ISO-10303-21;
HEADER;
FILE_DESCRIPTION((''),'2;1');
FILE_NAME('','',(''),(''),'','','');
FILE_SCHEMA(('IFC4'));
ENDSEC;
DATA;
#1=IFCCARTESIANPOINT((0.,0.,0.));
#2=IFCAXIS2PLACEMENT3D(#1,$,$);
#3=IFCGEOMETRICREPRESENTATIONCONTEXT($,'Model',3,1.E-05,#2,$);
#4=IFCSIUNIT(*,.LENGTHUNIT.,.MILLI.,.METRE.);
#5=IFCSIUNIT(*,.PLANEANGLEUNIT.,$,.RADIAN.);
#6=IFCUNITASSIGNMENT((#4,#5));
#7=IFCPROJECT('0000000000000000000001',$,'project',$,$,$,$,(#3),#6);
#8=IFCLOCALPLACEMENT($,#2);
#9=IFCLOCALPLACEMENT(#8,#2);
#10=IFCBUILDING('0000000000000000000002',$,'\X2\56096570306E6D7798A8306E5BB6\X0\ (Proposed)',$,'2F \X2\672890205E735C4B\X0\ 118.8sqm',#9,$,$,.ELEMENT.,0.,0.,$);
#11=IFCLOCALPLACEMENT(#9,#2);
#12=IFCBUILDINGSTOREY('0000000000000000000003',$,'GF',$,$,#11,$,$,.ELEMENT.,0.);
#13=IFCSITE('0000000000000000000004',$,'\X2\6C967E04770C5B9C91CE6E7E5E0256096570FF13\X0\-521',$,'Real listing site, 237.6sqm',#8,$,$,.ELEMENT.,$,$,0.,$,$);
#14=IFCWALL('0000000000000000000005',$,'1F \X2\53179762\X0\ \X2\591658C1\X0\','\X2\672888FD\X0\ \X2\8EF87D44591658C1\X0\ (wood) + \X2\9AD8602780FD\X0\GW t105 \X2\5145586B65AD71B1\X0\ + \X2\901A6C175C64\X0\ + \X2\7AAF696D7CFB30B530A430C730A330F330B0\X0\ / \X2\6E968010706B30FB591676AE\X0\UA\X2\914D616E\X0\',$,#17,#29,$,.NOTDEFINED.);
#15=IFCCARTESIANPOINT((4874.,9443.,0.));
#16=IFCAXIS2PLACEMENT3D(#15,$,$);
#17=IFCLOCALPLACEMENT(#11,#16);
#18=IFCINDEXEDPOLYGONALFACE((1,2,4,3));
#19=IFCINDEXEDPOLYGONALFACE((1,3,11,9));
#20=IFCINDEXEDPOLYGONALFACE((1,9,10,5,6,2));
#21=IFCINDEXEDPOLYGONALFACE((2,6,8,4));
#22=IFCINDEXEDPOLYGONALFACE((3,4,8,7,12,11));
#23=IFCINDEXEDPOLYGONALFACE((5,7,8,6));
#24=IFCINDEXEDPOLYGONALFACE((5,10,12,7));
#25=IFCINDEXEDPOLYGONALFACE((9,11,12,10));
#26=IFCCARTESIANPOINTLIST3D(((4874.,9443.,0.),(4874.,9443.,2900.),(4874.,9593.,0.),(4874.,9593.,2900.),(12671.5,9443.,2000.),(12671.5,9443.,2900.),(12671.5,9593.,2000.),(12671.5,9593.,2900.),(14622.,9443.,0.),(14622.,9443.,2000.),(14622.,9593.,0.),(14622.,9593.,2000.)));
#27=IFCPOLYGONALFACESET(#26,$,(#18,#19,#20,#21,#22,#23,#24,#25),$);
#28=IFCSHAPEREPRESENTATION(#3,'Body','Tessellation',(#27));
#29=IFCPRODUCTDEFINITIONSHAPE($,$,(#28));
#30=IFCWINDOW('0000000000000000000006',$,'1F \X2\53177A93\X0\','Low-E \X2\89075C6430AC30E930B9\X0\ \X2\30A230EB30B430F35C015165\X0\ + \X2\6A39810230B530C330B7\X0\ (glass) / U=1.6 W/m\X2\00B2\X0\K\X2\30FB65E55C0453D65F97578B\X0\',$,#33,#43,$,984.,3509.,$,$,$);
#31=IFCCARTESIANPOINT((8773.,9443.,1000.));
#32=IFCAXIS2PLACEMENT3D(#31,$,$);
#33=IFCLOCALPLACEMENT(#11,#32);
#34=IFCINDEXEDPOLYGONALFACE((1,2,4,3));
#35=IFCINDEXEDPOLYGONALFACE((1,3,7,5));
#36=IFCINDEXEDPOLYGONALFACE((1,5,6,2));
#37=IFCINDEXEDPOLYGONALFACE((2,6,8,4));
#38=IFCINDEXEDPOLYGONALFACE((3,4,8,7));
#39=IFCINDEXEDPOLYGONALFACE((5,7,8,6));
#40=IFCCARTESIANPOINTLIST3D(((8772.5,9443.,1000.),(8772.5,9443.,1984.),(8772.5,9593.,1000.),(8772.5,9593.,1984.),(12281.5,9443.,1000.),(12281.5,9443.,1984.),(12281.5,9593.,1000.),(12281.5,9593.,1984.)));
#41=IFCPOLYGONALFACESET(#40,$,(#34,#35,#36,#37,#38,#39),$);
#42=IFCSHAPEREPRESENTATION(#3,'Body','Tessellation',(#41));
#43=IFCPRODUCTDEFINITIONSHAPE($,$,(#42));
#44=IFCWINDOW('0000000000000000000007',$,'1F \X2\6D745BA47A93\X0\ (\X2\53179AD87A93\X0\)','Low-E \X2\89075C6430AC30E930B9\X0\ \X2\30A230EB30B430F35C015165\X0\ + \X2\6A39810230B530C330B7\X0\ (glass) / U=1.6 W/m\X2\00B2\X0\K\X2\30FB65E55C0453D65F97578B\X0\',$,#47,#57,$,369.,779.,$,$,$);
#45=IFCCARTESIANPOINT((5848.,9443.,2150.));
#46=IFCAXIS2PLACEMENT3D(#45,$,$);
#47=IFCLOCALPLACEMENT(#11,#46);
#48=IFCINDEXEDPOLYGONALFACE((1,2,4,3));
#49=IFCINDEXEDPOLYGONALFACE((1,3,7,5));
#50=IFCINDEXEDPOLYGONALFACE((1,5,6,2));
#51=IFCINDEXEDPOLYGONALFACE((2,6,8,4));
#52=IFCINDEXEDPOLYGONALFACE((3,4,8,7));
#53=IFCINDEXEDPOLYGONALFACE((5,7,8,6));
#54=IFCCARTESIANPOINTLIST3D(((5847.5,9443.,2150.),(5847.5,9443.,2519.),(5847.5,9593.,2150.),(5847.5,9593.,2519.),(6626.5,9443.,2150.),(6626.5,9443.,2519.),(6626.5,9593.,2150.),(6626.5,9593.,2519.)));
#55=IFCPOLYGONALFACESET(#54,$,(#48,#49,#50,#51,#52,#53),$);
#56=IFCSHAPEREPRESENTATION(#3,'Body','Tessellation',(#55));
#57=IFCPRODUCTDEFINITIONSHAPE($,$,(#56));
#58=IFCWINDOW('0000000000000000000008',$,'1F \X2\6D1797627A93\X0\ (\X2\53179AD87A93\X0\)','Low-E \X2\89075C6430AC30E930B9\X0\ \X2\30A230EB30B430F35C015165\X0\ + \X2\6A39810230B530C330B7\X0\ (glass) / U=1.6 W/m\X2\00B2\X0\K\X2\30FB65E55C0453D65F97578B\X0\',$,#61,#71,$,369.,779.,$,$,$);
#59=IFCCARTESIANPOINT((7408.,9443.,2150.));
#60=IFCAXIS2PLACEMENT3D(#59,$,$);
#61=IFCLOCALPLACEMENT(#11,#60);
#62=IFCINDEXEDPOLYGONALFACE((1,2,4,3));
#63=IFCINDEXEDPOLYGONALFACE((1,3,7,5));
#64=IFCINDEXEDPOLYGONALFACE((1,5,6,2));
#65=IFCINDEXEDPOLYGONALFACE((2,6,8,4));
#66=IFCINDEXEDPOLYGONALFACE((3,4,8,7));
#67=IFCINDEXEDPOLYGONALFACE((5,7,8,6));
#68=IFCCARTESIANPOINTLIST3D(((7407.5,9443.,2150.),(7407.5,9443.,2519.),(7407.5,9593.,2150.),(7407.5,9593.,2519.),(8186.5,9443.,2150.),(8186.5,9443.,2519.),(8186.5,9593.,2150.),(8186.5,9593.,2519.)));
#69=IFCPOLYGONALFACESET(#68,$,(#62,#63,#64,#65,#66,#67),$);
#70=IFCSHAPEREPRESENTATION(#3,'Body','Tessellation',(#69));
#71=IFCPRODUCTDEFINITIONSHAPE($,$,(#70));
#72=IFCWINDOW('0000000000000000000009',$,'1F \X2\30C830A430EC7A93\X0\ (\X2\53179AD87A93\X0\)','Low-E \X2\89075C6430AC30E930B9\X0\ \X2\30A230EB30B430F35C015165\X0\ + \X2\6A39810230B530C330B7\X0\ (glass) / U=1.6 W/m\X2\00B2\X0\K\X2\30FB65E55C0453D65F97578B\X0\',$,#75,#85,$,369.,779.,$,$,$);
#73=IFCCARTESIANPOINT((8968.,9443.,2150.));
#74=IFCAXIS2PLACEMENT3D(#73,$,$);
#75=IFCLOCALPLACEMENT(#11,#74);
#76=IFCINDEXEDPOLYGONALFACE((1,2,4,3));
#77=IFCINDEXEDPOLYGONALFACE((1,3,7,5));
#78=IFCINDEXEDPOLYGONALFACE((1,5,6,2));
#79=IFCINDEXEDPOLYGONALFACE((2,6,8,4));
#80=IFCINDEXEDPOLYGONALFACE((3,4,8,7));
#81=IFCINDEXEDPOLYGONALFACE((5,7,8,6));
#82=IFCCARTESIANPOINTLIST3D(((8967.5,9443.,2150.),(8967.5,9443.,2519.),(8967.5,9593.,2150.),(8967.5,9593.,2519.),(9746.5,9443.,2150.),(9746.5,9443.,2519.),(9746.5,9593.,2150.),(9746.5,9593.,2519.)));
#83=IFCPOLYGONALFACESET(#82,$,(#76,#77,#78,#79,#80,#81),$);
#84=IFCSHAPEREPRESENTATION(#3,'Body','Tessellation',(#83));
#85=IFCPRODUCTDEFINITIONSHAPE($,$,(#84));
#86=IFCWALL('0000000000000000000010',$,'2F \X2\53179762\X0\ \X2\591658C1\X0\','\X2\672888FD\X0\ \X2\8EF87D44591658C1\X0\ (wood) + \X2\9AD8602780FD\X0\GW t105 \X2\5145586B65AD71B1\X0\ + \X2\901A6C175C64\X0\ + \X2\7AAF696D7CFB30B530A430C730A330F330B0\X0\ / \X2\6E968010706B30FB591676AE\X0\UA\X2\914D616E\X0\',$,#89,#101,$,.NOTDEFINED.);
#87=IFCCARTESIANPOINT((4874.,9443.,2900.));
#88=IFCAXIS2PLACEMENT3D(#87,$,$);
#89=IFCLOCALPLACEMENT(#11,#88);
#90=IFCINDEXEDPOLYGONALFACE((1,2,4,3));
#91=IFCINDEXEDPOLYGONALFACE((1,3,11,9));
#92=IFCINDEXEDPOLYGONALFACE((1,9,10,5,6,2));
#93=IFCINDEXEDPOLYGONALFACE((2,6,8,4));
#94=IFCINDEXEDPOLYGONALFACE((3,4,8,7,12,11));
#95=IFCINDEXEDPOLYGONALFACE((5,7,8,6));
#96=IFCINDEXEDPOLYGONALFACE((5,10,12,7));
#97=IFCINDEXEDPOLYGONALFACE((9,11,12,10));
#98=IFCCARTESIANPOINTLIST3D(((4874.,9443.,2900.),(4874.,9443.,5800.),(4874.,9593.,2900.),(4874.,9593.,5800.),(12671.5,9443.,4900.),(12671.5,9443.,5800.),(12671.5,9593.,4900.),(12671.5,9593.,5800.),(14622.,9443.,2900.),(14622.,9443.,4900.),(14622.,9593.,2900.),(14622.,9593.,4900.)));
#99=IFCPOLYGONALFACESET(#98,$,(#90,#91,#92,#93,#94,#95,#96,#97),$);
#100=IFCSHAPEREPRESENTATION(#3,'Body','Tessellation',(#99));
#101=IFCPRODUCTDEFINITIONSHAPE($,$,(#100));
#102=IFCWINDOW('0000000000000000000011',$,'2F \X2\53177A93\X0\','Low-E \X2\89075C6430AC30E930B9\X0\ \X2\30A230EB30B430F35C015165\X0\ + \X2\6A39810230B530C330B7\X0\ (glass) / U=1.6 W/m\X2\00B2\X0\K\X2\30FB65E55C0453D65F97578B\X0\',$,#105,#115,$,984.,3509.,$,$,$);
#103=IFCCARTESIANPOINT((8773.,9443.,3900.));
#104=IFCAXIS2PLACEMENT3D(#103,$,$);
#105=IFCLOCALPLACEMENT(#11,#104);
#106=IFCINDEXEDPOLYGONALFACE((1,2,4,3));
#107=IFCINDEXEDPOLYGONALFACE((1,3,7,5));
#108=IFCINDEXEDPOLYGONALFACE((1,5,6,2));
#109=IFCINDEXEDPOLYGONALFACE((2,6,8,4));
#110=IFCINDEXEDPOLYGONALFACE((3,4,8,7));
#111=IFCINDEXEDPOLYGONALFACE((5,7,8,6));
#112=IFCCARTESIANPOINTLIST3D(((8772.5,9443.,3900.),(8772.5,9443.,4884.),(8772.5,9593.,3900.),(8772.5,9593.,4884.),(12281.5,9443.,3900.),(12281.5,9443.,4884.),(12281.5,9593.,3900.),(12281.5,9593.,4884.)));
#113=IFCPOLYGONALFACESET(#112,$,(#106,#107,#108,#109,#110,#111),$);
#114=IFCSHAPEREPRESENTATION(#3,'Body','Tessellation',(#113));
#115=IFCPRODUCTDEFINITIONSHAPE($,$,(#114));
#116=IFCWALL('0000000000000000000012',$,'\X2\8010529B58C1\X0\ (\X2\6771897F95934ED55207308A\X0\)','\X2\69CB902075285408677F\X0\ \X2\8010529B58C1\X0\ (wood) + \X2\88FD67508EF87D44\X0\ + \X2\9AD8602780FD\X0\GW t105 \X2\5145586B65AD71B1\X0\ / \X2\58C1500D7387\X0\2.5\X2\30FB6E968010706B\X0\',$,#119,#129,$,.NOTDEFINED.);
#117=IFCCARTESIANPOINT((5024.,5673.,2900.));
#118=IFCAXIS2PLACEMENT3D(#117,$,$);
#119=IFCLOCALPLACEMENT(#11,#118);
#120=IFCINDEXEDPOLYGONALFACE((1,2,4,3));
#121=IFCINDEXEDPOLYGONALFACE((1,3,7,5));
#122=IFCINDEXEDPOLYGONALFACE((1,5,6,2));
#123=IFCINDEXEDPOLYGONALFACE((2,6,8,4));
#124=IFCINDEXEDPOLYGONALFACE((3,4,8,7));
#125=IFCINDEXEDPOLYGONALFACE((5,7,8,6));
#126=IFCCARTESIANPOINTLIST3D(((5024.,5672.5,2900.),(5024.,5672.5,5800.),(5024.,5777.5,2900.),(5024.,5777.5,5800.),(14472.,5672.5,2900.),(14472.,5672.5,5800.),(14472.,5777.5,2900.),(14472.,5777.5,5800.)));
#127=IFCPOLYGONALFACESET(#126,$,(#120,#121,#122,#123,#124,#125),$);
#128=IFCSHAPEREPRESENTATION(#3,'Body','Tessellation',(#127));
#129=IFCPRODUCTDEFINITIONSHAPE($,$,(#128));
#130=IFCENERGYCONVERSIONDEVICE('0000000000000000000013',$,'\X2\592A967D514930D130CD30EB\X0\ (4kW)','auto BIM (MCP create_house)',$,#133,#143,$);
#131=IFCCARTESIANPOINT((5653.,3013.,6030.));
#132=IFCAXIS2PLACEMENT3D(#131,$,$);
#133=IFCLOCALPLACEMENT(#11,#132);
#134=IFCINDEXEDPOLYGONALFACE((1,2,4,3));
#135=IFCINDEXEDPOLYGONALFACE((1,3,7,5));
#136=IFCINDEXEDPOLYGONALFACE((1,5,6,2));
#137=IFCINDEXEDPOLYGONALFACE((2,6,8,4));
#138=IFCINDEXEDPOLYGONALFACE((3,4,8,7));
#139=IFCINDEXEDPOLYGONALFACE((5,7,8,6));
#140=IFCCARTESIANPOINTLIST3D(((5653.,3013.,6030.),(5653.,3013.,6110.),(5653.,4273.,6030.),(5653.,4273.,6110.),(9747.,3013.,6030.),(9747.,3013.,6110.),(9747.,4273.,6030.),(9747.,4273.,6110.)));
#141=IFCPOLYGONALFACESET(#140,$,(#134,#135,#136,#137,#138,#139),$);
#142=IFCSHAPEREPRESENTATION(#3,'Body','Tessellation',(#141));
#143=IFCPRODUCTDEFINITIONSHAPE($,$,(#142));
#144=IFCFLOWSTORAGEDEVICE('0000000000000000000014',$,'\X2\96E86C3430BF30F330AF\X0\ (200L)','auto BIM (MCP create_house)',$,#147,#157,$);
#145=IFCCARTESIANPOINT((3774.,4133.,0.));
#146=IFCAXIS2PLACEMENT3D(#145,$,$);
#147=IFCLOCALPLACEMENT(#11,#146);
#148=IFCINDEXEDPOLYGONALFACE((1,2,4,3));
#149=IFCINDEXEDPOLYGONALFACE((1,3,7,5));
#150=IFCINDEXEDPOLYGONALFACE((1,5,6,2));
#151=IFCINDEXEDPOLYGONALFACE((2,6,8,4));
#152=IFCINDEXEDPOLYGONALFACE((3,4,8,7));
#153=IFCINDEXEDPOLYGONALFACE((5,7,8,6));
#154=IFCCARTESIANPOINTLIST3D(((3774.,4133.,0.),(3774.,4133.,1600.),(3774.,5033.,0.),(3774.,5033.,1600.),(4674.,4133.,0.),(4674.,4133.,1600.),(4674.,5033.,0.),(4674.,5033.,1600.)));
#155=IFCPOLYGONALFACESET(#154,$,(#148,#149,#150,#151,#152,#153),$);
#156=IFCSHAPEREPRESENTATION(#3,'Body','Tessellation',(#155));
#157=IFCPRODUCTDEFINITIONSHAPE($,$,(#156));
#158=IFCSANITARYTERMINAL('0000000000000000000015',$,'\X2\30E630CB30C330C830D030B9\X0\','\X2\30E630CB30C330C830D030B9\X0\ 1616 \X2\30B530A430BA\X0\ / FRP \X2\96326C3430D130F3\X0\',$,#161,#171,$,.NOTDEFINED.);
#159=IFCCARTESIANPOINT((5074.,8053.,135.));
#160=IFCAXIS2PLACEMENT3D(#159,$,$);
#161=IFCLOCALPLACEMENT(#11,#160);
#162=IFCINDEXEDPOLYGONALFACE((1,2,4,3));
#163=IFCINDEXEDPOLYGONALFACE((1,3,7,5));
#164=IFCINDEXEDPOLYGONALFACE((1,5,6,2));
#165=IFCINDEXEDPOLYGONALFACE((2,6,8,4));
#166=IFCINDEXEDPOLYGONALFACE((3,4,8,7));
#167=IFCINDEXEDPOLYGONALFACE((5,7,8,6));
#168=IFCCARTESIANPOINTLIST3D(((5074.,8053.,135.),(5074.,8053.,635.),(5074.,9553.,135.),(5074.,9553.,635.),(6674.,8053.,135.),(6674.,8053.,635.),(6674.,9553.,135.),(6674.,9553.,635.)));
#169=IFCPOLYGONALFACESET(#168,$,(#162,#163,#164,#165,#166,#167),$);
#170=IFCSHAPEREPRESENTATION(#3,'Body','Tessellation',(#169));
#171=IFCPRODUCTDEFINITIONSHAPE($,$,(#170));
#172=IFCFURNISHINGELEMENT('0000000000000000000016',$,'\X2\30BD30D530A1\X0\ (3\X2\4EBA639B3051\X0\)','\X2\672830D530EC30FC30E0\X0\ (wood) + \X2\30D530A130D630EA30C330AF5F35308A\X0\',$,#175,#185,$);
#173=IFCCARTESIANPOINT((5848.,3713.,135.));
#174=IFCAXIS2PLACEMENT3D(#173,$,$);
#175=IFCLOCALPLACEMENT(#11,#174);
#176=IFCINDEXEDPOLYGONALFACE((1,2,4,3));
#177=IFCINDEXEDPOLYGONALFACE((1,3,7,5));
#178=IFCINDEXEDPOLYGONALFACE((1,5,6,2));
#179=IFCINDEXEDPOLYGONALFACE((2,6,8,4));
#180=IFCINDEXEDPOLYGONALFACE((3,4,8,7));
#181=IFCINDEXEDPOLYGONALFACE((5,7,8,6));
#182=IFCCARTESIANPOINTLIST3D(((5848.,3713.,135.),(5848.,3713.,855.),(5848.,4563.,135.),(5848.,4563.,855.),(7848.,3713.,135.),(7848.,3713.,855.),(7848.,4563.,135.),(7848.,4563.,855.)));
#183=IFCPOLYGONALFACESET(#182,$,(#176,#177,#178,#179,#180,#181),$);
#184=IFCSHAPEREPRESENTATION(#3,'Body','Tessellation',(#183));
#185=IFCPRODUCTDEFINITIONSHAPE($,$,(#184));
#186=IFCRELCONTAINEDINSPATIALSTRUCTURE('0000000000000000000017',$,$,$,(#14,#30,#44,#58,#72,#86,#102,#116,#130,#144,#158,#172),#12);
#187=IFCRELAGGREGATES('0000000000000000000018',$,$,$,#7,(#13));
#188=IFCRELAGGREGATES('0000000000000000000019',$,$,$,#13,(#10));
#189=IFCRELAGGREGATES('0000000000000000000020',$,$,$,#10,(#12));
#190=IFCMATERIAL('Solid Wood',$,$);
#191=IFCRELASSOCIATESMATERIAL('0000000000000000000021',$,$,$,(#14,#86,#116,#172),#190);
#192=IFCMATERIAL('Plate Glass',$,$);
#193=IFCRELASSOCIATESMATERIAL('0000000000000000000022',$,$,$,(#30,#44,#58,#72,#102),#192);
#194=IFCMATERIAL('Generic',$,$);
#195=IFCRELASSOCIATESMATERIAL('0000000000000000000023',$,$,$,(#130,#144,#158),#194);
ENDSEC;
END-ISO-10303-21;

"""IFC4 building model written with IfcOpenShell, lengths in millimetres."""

from ifc_helpers import new_model, si_unit, frame, frame_2d, origin, place, context, project, spatial, rectangle, extrude, material, element, fill, save


model = new_model("IFC4")

# Units and contexts
model_context = context("Model", 3, precision=1e-05, world=origin())
ifc_project = project(units=[si_unit("LENGTHUNIT", "METRE", prefix="MILLI"), si_unit("PLANEANGLEUNIT", "RADIAN")], contexts=[model_context])

# Site, building, storey
site_placement = place(None, origin())
site = spatial("IfcSite", under=ifc_project, at=site_placement, Name="沖縄県宜野湾市嘉数３-521", ObjectType="Real listing site, 237.6sqm", CompositionType="ELEMENT", RefElevation=0.0)
building_placement = place(site_placement, origin())
building = spatial("IfcBuilding", under=site, at=building_placement, Name="嘉数の海風の家 (Proposed)", ObjectType="2F 木造平屋 118.8sqm", CompositionType="ELEMENT", ElevationOfRefHeight=0.0, ElevationOfTerrain=0.0)
storey_placement = place(building_placement, origin())
storey = spatial("IfcBuildingStorey", under=building, at=storey_placement, Name="GF", CompositionType="ELEMENT", Elevation=0.0)

# Wall, openings, windows
ifc_material_1 = material(Name="Solid Wood")
wall_1_placement = place(storey_placement, frame((4874.0, 9443.0, 0.0)))
wall_1 = element("IfcWall", 1, at=wall_1_placement, inside=storey, material=ifc_material_1, Name="1F 北面 外壁", Description="木製 軸組外壁 (wood) + 高性能GW t105 充填断熱 + 通気層 + 窯業系サイディング / 準耐火・外皮UA配慮", PredefinedType="NOTDEFINED", context=model_context, shape_type="SweptSolid", body=[
    extrude(rectangle(XDim=9748.0, YDim=150.0, at=frame_2d((4874.0, 75.0))), frame((4874.0, 9443.0, 0.0)), (0.0, 0.0, 1.0), 2900.0),
])
opening_1_placement = place(storey_placement, frame((8773.0, 9443.0, 1000.0)))
opening_1 = element("IfcOpeningElement", 2, at=opening_1_placement, cuts=wall_1, PredefinedType="NOTDEFINED", context=model_context, shape_type="SweptSolid", body=[
    extrude(rectangle(XDim=3509.0, YDim=150.0, at=frame_2d((1754.0, 75.0))), frame((8773.0, 9443.0, 1000.0)), (0.0, 0.0, 1.0), 984.0),
])
opening_2_placement = place(storey_placement, frame((5848.0, 9443.0, 2150.0)))
opening_2 = element("IfcOpeningElement", 3, at=opening_2_placement, cuts=wall_1, PredefinedType="NOTDEFINED", context=model_context, shape_type="SweptSolid", body=[
    extrude(rectangle(XDim=779.0, YDim=150.0, at=frame_2d((389.0, 75.0))), frame((5848.0, 9443.0, 2150.0)), (0.0, 0.0, 1.0), 369.0),
])
opening_3_placement = place(storey_placement, frame((7408.0, 9443.0, 2150.0)))
opening_3 = element("IfcOpeningElement", 4, at=opening_3_placement, cuts=wall_1, PredefinedType="NOTDEFINED", context=model_context, shape_type="SweptSolid", body=[
    extrude(rectangle(XDim=779.0, YDim=150.0, at=frame_2d((389.0, 75.0))), frame((7408.0, 9443.0, 2150.0)), (0.0, 0.0, 1.0), 369.0),
])
opening_4_placement = place(storey_placement, frame((8968.0, 9443.0, 2150.0)))
opening_4 = element("IfcOpeningElement", 5, at=opening_4_placement, cuts=wall_1, PredefinedType="NOTDEFINED", context=model_context, shape_type="SweptSolid", body=[
    extrude(rectangle(XDim=779.0, YDim=150.0, at=frame_2d((389.0, 75.0))), frame((8968.0, 9443.0, 2150.0)), (0.0, 0.0, 1.0), 369.0),
])
ifc_material_2 = material(Name="Plate Glass")
window_1_placement = place(storey_placement, frame((8773.0, 9443.0, 1000.0)))
window_1 = element("IfcWindow", 6, at=window_1_placement, inside=storey, material=ifc_material_2, Name="1F 北窓", Description="Low-E 複層ガラス アルゴン封入 + 樹脂サッシ (glass) / U=1.6 W/m²K・日射取得型", OverallHeight=984.0, OverallWidth=3509.0, context=model_context, shape_type="SweptSolid", body=[
    extrude(rectangle(XDim=3509.0, YDim=150.0, at=frame_2d((1754.0, 75.0))), frame((8773.0, 9443.0, 1000.0)), (0.0, 0.0, 1.0), 984.0),
])
fill(opening_1, window_1)
window_2_placement = place(storey_placement, frame((5848.0, 9443.0, 2150.0)))
window_2 = element("IfcWindow", 7, at=window_2_placement, inside=storey, material=ifc_material_2, Name="1F 浴室窓 (北高窓)", Description="Low-E 複層ガラス アルゴン封入 + 樹脂サッシ (glass) / U=1.6 W/m²K・日射取得型", OverallHeight=369.0, OverallWidth=779.0, context=model_context, shape_type="SweptSolid", body=[
    extrude(rectangle(XDim=779.0, YDim=150.0, at=frame_2d((389.0, 75.0))), frame((5848.0, 9443.0, 2150.0)), (0.0, 0.0, 1.0), 369.0),
])
fill(opening_2, window_2)
window_3_placement = place(storey_placement, frame((7408.0, 9443.0, 2150.0)))
window_3 = element("IfcWindow", 8, at=window_3_placement, inside=storey, material=ifc_material_2, Name="1F 洗面窓 (北高窓)", Description="Low-E 複層ガラス アルゴン封入 + 樹脂サッシ (glass) / U=1.6 W/m²K・日射取得型", OverallHeight=369.0, OverallWidth=779.0, context=model_context, shape_type="SweptSolid", body=[
    extrude(rectangle(XDim=779.0, YDim=150.0, at=frame_2d((389.0, 75.0))), frame((7408.0, 9443.0, 2150.0)), (0.0, 0.0, 1.0), 369.0),
])
fill(opening_3, window_3)
window_4_placement = place(storey_placement, frame((8968.0, 9443.0, 2150.0)))
window_4 = element("IfcWindow", 9, at=window_4_placement, inside=storey, material=ifc_material_2, Name="1F トイレ窓 (北高窓)", Description="Low-E 複層ガラス アルゴン封入 + 樹脂サッシ (glass) / U=1.6 W/m²K・日射取得型", OverallHeight=369.0, OverallWidth=779.0, context=model_context, shape_type="SweptSolid", body=[
    extrude(rectangle(XDim=779.0, YDim=150.0, at=frame_2d((389.0, 75.0))), frame((8968.0, 9443.0, 2150.0)), (0.0, 0.0, 1.0), 369.0),
])
fill(opening_4, window_4)

# Wall, opening, window
wall_2_placement = place(storey_placement, frame((4874.0, 9443.0, 2900.0)))
wall_2 = element("IfcWall", 10, at=wall_2_placement, inside=storey, material=ifc_material_1, Name="2F 北面 外壁", Description="木製 軸組外壁 (wood) + 高性能GW t105 充填断熱 + 通気層 + 窯業系サイディング / 準耐火・外皮UA配慮", PredefinedType="NOTDEFINED", context=model_context, shape_type="SweptSolid", body=[
    extrude(rectangle(XDim=9748.0, YDim=150.0, at=frame_2d((4874.0, 75.0))), frame((4874.0, 9443.0, 2900.0)), (0.0, 0.0, 1.0), 2900.0),
])
opening_5_placement = place(storey_placement, frame((8773.0, 9443.0, 3900.0)))
opening_5 = element("IfcOpeningElement", 11, at=opening_5_placement, cuts=wall_2, PredefinedType="NOTDEFINED", context=model_context, shape_type="SweptSolid", body=[
    extrude(rectangle(XDim=3509.0, YDim=150.0, at=frame_2d((1754.0, 75.0))), frame((8773.0, 9443.0, 3900.0)), (0.0, 0.0, 1.0), 984.0),
])
window_5_placement = place(storey_placement, frame((8773.0, 9443.0, 3900.0)))
window_5 = element("IfcWindow", 12, at=window_5_placement, inside=storey, material=ifc_material_2, Name="2F 北窓", Description="Low-E 複層ガラス アルゴン封入 + 樹脂サッシ (glass) / U=1.6 W/m²K・日射取得型", OverallHeight=984.0, OverallWidth=3509.0, context=model_context, shape_type="SweptSolid", body=[
    extrude(rectangle(XDim=3509.0, YDim=150.0, at=frame_2d((1754.0, 75.0))), frame((8773.0, 9443.0, 3900.0)), (0.0, 0.0, 1.0), 984.0),
])
fill(opening_5, window_5)

# Wall
wall_3_placement = place(storey_placement, frame((5024.0, 5673.0, 2900.0)))
element("IfcWall", 13, at=wall_3_placement, inside=storey, material=ifc_material_1, Name="耐力壁 (東西間仕切り)", Description="構造用合板 耐力壁 (wood) + 製材軸組 + 高性能GW t105 充填断熱 / 壁倍率2.5・準耐火", PredefinedType="NOTDEFINED", context=model_context, shape_type="SweptSolid", body=[
    extrude(rectangle(XDim=9448.0, YDim=105.0, at=frame_2d((4724.0, 52.0))), frame((5024.0, 5673.0, 2900.0)), (0.0, 0.0, 1.0), 2900.0),
])

# Energy conversion device
ifc_material_3 = material(Name="Generic")
energy_conversion_device_placement = place(storey_placement, frame((5653.0, 3013.0, 6030.0)))
element("IfcEnergyConversionDevice", 14, at=energy_conversion_device_placement, inside=storey, material=ifc_material_3, Name="太陽光パネル (4kW)", Description="auto BIM (MCP create_house)", context=model_context, shape_type="SweptSolid", body=[
    extrude(rectangle(XDim=4094.0, YDim=1260.0, at=frame_2d((2047.0, 630.0))), frame((5653.0, 3013.0, 6030.0)), (0.0, 0.0, 1.0), 80.0),
])

# Flow storage device
flow_storage_device_placement = place(storey_placement, frame((3774.0, 4133.0, 0.0)))
element("IfcFlowStorageDevice", 15, at=flow_storage_device_placement, inside=storey, material=ifc_material_3, Name="雨水タンク (200L)", Description="auto BIM (MCP create_house)", context=model_context, shape_type="SweptSolid", body=[
    extrude(rectangle(XDim=900.0, YDim=900.0, at=frame_2d((450.0, 450.0))), frame((3774.0, 4133.0, 0.0)), (0.0, 0.0, 1.0), 1600.0),
])

# Sanitary terminal
sanitary_terminal_placement = place(storey_placement, frame((5074.0, 8053.0, 135.0)))
element("IfcSanitaryTerminal", 16, at=sanitary_terminal_placement, inside=storey, material=ifc_material_3, Name="ユニットバス", Description="ユニットバス 1616 サイズ / FRP 防水パン", PredefinedType="NOTDEFINED", context=model_context, shape_type="SweptSolid", body=[
    extrude(rectangle(XDim=1600.0, YDim=1500.0, at=frame_2d((800.0, 750.0))), frame((5074.0, 8053.0, 135.0)), (0.0, 0.0, 1.0), 500.0),
])

# Furnishing element
furnishing_1_placement = place(storey_placement, frame((5848.0, 3713.0, 135.0)))
element("IfcFurnishingElement", 17, at=furnishing_1_placement, inside=storey, material=ifc_material_1, Name="ソファ (3人掛け)", Description="木フレーム (wood) + ファブリック張り", context=model_context, shape_type="SweptSolid", body=[
    extrude(rectangle(XDim=2000.0, YDim=850.0, at=frame_2d((1000.0, 425.0))), frame((5848.0, 3713.0, 135.0)), (0.0, 0.0, 1.0), 720.0),
])

save(model, "model.ifc")
